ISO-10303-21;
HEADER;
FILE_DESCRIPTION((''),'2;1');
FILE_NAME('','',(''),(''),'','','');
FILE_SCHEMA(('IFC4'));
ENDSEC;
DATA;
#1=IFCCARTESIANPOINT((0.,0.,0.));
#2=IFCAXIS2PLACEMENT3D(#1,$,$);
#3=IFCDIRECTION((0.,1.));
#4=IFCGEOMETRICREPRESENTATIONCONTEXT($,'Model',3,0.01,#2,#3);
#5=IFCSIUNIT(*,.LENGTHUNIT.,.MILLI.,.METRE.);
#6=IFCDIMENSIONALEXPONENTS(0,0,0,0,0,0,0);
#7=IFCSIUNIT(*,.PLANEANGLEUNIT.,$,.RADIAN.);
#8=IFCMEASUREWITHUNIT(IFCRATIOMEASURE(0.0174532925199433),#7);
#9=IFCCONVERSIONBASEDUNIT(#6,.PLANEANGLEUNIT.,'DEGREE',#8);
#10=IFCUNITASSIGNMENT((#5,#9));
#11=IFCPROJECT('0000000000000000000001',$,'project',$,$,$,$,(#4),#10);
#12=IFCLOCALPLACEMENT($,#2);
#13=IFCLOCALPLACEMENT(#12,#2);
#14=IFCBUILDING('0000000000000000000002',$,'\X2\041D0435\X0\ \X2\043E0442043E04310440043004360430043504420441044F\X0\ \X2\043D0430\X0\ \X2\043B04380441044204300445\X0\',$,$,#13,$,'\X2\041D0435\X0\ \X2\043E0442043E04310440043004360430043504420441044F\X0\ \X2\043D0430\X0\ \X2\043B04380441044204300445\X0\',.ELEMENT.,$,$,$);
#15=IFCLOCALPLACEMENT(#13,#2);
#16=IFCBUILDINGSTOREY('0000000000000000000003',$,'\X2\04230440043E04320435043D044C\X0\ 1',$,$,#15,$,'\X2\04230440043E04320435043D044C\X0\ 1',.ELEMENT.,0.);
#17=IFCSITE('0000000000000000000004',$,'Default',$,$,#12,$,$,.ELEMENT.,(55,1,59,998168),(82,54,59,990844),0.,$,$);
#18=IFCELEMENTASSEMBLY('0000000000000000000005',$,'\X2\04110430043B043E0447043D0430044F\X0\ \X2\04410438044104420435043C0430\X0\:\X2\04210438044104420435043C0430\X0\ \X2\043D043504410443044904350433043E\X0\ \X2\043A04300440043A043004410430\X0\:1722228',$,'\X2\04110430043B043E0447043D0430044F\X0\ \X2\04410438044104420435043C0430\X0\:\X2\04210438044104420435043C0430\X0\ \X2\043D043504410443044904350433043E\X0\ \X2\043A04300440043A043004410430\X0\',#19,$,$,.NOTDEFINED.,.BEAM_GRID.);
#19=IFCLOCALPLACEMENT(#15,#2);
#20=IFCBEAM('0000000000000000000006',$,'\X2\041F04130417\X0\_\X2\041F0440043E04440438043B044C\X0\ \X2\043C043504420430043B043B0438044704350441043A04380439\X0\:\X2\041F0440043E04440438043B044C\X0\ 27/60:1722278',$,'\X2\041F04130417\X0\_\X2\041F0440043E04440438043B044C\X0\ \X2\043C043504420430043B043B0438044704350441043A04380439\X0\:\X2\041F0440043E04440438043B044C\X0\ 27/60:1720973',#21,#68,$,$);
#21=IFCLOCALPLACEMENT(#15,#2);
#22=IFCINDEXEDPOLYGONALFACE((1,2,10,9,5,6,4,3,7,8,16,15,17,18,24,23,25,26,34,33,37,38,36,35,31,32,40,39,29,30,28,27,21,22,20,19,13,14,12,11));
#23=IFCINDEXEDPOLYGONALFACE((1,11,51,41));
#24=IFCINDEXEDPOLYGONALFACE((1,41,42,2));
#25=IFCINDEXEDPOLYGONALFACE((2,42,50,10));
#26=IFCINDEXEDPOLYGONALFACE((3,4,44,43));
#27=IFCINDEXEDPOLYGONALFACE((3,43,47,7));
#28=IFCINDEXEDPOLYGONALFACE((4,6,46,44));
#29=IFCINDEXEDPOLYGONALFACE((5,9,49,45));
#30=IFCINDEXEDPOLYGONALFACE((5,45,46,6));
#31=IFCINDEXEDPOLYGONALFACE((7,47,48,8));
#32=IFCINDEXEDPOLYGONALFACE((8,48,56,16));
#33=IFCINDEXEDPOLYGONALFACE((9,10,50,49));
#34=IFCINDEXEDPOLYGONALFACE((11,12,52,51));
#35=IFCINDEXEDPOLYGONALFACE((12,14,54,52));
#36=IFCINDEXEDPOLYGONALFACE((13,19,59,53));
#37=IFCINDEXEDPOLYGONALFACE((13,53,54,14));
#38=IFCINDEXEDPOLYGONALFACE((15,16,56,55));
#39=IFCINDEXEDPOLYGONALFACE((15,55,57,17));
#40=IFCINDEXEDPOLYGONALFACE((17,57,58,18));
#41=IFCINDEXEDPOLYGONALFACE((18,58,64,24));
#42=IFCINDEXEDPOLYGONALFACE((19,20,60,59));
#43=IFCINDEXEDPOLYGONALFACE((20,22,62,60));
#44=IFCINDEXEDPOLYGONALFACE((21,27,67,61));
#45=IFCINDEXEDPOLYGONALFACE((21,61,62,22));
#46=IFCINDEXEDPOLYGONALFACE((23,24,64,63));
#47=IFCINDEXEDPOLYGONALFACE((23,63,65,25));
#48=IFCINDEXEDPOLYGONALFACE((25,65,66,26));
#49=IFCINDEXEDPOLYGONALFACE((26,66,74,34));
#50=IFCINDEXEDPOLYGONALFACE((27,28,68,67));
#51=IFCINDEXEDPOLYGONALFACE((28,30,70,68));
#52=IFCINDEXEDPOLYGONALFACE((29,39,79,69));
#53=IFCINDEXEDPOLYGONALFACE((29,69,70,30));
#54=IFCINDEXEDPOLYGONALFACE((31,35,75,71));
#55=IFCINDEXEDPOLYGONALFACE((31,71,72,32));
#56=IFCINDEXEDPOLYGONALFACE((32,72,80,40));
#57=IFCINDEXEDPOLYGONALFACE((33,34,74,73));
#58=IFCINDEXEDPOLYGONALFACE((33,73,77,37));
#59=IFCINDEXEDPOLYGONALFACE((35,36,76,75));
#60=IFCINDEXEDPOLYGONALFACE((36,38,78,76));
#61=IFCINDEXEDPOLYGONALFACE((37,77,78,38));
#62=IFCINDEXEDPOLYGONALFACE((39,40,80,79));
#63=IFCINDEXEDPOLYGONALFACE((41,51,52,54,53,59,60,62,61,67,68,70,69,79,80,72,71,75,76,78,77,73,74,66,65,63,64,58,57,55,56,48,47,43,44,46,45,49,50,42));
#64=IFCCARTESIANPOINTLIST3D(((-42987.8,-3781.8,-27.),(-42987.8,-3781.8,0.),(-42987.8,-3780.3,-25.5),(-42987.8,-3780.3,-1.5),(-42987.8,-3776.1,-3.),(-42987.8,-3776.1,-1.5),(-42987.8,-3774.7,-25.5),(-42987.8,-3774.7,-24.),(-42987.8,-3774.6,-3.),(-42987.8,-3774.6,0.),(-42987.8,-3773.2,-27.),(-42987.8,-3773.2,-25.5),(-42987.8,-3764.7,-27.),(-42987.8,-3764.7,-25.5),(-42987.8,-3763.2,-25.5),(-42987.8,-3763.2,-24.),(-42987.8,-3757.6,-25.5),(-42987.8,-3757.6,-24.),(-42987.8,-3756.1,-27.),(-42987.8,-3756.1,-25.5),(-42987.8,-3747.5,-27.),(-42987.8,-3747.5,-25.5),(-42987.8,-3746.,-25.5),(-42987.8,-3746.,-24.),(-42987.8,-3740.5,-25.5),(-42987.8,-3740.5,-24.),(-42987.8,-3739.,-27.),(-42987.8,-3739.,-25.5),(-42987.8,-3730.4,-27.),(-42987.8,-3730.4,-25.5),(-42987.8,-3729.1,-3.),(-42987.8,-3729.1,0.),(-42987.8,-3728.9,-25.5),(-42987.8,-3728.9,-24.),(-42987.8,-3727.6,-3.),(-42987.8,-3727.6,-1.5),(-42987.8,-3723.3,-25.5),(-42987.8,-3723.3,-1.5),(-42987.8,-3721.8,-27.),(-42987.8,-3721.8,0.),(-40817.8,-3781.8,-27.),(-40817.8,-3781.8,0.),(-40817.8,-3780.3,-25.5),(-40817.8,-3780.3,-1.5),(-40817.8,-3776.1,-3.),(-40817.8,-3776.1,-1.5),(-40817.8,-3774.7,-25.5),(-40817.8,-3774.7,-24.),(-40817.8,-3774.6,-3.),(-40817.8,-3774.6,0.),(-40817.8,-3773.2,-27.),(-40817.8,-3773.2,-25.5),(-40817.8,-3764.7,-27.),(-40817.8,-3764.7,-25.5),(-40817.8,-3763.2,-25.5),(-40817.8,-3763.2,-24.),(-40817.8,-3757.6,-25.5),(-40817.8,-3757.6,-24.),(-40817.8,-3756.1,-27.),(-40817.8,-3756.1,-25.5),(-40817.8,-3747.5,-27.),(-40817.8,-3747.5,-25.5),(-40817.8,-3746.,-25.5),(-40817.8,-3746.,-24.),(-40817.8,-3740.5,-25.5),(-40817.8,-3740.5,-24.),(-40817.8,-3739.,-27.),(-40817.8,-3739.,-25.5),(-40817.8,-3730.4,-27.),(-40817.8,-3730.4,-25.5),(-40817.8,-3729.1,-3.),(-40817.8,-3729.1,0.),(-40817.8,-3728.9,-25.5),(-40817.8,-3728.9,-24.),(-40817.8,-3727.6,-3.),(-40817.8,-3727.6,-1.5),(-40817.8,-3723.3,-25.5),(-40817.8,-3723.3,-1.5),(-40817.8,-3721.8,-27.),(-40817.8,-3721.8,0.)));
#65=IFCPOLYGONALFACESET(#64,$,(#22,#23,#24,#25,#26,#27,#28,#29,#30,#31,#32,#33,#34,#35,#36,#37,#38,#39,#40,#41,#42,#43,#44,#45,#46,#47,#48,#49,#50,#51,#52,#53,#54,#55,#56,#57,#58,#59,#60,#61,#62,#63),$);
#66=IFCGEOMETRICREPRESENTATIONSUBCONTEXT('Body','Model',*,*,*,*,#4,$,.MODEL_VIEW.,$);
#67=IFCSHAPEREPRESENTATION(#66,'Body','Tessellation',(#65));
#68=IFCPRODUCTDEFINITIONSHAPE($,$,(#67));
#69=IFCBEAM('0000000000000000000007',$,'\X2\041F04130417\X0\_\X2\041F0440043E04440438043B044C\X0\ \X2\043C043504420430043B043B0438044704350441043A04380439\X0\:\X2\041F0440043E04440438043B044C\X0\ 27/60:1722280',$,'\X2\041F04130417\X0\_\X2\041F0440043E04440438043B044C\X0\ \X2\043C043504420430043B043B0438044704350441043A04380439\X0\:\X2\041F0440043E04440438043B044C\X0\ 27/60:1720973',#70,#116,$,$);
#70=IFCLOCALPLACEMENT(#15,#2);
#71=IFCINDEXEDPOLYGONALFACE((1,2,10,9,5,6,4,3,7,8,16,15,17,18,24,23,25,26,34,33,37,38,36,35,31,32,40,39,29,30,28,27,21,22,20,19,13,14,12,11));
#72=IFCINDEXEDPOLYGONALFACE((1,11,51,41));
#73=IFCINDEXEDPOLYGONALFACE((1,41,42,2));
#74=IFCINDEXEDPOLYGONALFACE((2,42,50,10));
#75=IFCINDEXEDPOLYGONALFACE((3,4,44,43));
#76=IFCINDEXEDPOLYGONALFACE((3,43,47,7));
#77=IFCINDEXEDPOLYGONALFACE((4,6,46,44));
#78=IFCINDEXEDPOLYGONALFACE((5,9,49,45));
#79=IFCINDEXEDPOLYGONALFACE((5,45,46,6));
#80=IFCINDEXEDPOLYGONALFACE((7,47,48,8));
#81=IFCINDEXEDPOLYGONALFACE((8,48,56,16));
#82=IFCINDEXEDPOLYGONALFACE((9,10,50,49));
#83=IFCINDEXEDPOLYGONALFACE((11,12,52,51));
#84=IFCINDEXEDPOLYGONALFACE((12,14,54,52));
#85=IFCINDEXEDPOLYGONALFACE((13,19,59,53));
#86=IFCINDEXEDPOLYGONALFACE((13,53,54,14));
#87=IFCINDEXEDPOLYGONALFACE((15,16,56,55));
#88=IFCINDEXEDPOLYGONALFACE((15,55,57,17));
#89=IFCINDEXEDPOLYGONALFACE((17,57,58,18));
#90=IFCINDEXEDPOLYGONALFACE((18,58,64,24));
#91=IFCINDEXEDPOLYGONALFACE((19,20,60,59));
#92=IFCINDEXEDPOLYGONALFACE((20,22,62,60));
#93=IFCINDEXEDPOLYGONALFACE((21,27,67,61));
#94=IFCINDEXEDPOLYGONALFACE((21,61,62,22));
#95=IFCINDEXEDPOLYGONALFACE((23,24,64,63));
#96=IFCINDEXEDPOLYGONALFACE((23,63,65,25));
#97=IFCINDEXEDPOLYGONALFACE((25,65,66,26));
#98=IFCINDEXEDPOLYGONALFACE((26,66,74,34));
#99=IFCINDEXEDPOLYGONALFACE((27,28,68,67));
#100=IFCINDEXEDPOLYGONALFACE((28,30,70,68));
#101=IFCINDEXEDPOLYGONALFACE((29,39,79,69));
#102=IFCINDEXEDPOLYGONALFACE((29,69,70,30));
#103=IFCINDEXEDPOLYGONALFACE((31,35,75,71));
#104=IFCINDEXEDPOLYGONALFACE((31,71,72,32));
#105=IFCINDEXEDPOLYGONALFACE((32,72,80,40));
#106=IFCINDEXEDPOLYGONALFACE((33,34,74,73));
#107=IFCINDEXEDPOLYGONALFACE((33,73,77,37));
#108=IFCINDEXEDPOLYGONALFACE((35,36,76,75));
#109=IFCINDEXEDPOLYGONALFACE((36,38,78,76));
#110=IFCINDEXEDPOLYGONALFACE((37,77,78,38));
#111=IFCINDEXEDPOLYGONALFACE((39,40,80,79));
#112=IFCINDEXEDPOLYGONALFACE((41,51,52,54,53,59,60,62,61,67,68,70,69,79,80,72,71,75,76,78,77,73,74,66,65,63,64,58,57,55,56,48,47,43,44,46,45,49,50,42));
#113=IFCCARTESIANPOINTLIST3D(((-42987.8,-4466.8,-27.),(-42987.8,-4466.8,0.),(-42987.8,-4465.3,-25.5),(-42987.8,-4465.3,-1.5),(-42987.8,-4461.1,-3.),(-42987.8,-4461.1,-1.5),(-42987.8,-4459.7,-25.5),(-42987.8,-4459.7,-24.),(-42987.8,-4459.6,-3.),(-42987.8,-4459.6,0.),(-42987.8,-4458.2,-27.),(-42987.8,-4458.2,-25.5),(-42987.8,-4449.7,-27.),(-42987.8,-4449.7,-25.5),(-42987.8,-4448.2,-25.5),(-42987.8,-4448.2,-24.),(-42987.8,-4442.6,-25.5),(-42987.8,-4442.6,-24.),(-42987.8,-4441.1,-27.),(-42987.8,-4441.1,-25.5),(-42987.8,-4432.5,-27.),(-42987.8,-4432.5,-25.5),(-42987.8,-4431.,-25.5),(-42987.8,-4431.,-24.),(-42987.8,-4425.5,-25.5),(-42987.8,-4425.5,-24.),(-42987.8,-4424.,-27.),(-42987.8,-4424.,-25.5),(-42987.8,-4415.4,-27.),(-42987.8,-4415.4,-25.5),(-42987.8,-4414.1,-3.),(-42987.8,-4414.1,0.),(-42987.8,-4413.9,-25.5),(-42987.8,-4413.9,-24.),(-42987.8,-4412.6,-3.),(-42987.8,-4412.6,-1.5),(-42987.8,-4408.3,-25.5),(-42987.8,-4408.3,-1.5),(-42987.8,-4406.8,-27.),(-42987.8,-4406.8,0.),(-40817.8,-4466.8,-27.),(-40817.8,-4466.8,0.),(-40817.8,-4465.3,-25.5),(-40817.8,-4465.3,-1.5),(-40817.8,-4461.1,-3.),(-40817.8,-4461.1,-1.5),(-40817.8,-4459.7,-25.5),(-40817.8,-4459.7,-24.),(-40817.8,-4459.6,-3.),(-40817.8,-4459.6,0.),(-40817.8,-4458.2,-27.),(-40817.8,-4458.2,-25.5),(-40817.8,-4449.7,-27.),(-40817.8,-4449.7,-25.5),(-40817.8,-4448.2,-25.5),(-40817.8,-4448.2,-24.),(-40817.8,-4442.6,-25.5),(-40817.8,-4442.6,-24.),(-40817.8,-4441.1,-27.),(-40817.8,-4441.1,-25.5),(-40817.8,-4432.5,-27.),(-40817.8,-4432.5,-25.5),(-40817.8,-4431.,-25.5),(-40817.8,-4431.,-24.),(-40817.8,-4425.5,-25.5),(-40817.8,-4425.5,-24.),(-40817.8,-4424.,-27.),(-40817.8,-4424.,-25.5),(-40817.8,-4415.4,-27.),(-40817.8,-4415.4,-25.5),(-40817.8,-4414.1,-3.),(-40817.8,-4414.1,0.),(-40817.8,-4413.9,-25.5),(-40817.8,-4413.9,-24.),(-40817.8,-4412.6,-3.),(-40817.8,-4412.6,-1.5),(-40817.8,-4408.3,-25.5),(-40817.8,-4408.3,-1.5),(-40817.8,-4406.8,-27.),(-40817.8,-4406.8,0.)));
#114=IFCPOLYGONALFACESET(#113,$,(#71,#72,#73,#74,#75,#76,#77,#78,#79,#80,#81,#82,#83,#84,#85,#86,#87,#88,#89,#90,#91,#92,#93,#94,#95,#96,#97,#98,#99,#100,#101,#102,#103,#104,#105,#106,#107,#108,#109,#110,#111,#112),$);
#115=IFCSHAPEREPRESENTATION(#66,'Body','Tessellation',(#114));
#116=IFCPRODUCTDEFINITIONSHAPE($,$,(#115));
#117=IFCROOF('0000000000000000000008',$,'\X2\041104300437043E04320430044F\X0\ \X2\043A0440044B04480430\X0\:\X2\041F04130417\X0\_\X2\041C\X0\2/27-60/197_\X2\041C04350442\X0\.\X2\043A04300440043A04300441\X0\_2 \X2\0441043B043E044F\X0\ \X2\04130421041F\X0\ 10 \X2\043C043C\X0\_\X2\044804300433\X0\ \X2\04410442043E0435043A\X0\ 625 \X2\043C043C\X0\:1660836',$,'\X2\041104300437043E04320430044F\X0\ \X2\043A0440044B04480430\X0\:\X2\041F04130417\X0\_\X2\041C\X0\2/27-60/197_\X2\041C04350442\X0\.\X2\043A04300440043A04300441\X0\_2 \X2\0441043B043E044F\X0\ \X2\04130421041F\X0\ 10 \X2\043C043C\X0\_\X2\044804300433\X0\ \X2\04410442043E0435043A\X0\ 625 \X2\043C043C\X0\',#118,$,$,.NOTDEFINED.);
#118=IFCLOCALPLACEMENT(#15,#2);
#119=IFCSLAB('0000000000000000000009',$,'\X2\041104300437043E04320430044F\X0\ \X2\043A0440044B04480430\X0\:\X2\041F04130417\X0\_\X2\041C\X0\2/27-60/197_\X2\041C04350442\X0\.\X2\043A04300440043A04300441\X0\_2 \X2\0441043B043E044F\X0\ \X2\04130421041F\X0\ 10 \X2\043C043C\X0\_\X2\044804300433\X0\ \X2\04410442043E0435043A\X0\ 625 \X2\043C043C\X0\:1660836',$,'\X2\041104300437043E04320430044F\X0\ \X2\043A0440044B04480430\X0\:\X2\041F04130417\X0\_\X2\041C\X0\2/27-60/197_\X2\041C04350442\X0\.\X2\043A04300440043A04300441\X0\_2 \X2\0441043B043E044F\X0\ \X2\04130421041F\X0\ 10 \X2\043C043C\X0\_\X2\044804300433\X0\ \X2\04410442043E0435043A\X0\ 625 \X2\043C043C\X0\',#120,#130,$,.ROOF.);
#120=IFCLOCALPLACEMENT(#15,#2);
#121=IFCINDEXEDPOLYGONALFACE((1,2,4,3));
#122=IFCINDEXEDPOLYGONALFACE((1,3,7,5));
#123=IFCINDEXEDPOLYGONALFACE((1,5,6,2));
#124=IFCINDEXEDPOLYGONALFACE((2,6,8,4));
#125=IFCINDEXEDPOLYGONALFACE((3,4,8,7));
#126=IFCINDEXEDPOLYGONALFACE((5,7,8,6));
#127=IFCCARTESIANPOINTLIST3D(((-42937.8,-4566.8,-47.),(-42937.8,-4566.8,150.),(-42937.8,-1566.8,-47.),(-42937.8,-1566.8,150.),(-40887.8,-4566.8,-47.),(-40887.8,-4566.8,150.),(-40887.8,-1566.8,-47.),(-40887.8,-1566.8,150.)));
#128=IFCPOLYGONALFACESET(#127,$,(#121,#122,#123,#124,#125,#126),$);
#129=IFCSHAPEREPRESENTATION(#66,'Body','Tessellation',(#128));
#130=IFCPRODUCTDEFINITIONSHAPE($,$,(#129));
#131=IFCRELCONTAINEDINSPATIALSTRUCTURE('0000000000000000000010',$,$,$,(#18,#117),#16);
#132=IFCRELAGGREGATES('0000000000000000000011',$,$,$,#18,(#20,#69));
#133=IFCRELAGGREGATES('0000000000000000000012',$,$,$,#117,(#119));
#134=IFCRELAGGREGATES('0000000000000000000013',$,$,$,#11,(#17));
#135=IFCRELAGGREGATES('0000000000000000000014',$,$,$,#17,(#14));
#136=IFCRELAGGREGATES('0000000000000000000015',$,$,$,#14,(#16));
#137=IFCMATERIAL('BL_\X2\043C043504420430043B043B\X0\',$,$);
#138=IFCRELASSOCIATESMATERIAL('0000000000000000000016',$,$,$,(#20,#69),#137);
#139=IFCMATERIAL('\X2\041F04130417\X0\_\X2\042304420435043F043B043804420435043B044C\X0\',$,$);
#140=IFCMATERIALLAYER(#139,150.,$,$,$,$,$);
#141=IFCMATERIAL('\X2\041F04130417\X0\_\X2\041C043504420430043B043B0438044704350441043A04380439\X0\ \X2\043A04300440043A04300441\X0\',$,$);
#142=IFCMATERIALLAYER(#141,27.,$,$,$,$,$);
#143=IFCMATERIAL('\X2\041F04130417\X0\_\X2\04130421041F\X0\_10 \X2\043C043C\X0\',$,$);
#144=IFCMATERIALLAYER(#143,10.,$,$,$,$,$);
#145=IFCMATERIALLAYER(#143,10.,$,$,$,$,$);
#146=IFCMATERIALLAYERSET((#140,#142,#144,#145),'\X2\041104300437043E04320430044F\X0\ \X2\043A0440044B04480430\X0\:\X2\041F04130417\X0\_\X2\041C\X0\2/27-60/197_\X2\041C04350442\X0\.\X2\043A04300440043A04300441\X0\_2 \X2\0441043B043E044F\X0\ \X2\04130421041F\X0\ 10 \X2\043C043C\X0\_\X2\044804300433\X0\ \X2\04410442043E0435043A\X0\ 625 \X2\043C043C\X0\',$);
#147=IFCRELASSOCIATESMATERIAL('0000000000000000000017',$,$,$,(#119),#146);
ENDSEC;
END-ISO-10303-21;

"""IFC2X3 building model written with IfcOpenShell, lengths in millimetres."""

from ifc_helpers import new_model, entity, si_unit, converted_unit, direction, frame, frame_2d, origin, place, context, subcontext, project, spatial, polyline, rectangle, outline, extrude, material, layer, layer_set, element, aggregate, save


model = new_model("IFC2X3")

# Units and contexts
model_context = context("Model", 3, precision=0.01, world=origin(), true_north=direction((0.0, 1.0)))
body_context = subcontext(model_context, "Body", "Model", "MODEL_VIEW")
ifc_project = project(units=[si_unit("LENGTHUNIT", "METRE", prefix="MILLI"), converted_unit("PLANEANGLEUNIT", "DEGREE", entity("IfcRatioMeasure", 0.0174532925199433), si_unit("PLANEANGLEUNIT", "RADIAN"), dimensions=[0, 0, 0, 0, 0, 0, 0])], contexts=[model_context])

# Site, building, storey
site_placement = place(None, origin())
site = spatial("IfcSite", under=ifc_project, at=site_placement, Name="Default", CompositionType="ELEMENT", RefLatitude=(55, 1, 59, 998168), RefLongitude=(82, 54, 59, 990844), RefElevation=0.0)
building_placement = place(site_placement, origin())
building = spatial("IfcBuilding", under=site, at=building_placement, Name="Не отображается на листах", LongName="Не отображается на листах", CompositionType="ELEMENT")
storey_placement = place(building_placement, frame((0.0, 0.0, 0.0)))
storey = spatial("IfcBuildingStorey", under=building, at=storey_placement, Name="Уровень 1", LongName="Уровень 1", CompositionType="ELEMENT", Elevation=0.0)

# Element assembly, beams
ifc_material_1 = material(Name="BL_металл")
assembly_1_placement = place(storey_placement, origin())
assembly_1 = element("IfcElementAssembly", 1, at=assembly_1_placement, inside=storey, Name="Балочная система:Система несущего каркаса:1722228", ObjectType="Балочная система:Система несущего каркаса", AssemblyPlace="NOTDEFINED", PredefinedType="BEAM_GRID")
beam_1_placement = place(assembly_1_placement, frame((-42987.8, -3751.8, 0.0)))
beam_1 = element("IfcBeam", 2, at=beam_1_placement, material=ifc_material_1, Name="ПГЗ_Профиль металлический:Профиль 27/60:1722278", ObjectType="ПГЗ_Профиль металлический:Профиль 27/60:1720973", context=body_context, shape_type="SweptSolid", body=[
    extrude(outline(polyline([(-18.4, -30.0), (8.6, -30.0), (8.6, -21.4), (7.1, -21.4), (7.1, -12.9), (8.6, -12.9), (8.6, -4.3), (7.1, -4.3), (7.1, 4.3), (8.6, 4.3), (8.6, 12.9), (7.1, 12.9), (7.1, 21.4), (8.6, 21.4), (8.6, 30.0), (-18.4, 30.0), (-18.4, 22.7), (-15.4, 22.7), (-15.4, 24.2), (-16.9, 24.2), (-16.9, 28.5), (7.1, 28.5), (7.1, 22.9), (5.6, 22.9), (5.6, 11.4), (7.1, 11.4), (7.1, 5.8), (5.6, 5.8), (5.6, -5.8), (7.1, -5.8), (7.1, -11.4), (5.6, -11.4), (5.6, -22.9), (7.1, -22.9), (7.1, -28.5), (-16.9, -28.5), (-16.9, -24.2), (-15.4, -24.2), (-15.4, -22.7), (-18.4, -22.7), (-18.4, -30.0)])), frame((0.0, 0.0, -18.4), z_axis=(1.0, 0.0, 0.0), x_axis=(0.0, 0.0, -1.0)), (0.0, 0.0, 1.0), 2170.0),
])
beam_2_placement = place(assembly_1_placement, frame((-42987.8, -4436.8, 0.0)))
beam_2 = element("IfcBeam", 3, at=beam_2_placement, material=ifc_material_1, Name="ПГЗ_Профиль металлический:Профиль 27/60:1722280", ObjectType="ПГЗ_Профиль металлический:Профиль 27/60:1720973", context=body_context, shape_type="SweptSolid", body=[
    extrude(outline(polyline([(-18.4, -30.0), (8.6, -30.0), (8.6, -21.4), (7.1, -21.4), (7.1, -12.9), (8.6, -12.9), (8.6, -4.3), (7.1, -4.3), (7.1, 4.3), (8.6, 4.3), (8.6, 12.9), (7.1, 12.9), (7.1, 21.4), (8.6, 21.4), (8.6, 30.0), (-18.4, 30.0), (-18.4, 22.7), (-15.4, 22.7), (-15.4, 24.2), (-16.9, 24.2), (-16.9, 28.5), (7.1, 28.5), (7.1, 22.9), (5.6, 22.9), (5.6, 11.4), (7.1, 11.4), (7.1, 5.8), (5.6, 5.8), (5.6, -5.8), (7.1, -5.8), (7.1, -11.4), (5.6, -11.4), (5.6, -22.9), (7.1, -22.9), (7.1, -28.5), (-16.9, -28.5), (-16.9, -24.2), (-15.4, -24.2), (-15.4, -22.7), (-18.4, -22.7), (-18.4, -30.0)])), frame((0.0, 0.0, -18.4), z_axis=(1.0, 0.0, 0.0), x_axis=(0.0, 0.0, -1.0)), (0.0, 0.0, 1.0), 2170.0),
])
aggregate(assembly_1, [beam_1, beam_2])

# Roof, slab
roof_placement = place(storey_placement, frame((-42937.8, -4566.8, -47.0)))
roof = element("IfcRoof", 4, at=roof_placement, inside=storey, Name="Базовая крыша:ПГЗ_М2/27-60/197_Мет.каркас_2 слоя ГСП 10 мм_шаг стоек 625 мм:1660836", ObjectType="Базовая крыша:ПГЗ_М2/27-60/197_Мет.каркас_2 слоя ГСП 10 мм_шаг стоек 625 мм", ShapeType="NOTDEFINED")
ifc_material_2 = material(Name="ПГЗ_Утеплитель")
ifc_layer_1 = layer(ifc_material_2, 150.0)
ifc_material_3 = material(Name="ПГЗ_Металлический каркас")
ifc_layer_2 = layer(ifc_material_3, 27.0)
ifc_material_4 = material(Name="ПГЗ_ГСП_10 мм")
ifc_layer_3 = layer(ifc_material_4, 10.0)
ifc_layer_4 = layer(ifc_material_4, 10.0)
ifc_layer_set = layer_set([ifc_layer_1, ifc_layer_2, ifc_layer_3, ifc_layer_4], Name="Базовая крыша:ПГЗ_М2/27-60/197_Мет.каркас_2 слоя ГСП 10 мм_шаг стоек 625 мм")
slab_placement = place(roof_placement, origin())
slab = element("IfcSlab", 5, at=slab_placement, material=ifc_layer_set, Name="Базовая крыша:ПГЗ_М2/27-60/197_Мет.каркас_2 слоя ГСП 10 мм_шаг стоек 625 мм:1660836", ObjectType="Базовая крыша:ПГЗ_М2/27-60/197_Мет.каркас_2 слоя ГСП 10 мм_шаг стоек 625 мм", PredefinedType="ROOF", context=body_context, shape_type="SweptSolid", body=[
    extrude(rectangle(XDim=2050.0, YDim=3000.0, at=frame_2d((0.0, 0.0), x_axis=(1.0, 0.0))), frame((1025.0, 1500.0, 0.0)), (0.0, 0.0, 1.0), 197.0),
])
aggregate(roof, [slab])

save(model, "model.ifc")
